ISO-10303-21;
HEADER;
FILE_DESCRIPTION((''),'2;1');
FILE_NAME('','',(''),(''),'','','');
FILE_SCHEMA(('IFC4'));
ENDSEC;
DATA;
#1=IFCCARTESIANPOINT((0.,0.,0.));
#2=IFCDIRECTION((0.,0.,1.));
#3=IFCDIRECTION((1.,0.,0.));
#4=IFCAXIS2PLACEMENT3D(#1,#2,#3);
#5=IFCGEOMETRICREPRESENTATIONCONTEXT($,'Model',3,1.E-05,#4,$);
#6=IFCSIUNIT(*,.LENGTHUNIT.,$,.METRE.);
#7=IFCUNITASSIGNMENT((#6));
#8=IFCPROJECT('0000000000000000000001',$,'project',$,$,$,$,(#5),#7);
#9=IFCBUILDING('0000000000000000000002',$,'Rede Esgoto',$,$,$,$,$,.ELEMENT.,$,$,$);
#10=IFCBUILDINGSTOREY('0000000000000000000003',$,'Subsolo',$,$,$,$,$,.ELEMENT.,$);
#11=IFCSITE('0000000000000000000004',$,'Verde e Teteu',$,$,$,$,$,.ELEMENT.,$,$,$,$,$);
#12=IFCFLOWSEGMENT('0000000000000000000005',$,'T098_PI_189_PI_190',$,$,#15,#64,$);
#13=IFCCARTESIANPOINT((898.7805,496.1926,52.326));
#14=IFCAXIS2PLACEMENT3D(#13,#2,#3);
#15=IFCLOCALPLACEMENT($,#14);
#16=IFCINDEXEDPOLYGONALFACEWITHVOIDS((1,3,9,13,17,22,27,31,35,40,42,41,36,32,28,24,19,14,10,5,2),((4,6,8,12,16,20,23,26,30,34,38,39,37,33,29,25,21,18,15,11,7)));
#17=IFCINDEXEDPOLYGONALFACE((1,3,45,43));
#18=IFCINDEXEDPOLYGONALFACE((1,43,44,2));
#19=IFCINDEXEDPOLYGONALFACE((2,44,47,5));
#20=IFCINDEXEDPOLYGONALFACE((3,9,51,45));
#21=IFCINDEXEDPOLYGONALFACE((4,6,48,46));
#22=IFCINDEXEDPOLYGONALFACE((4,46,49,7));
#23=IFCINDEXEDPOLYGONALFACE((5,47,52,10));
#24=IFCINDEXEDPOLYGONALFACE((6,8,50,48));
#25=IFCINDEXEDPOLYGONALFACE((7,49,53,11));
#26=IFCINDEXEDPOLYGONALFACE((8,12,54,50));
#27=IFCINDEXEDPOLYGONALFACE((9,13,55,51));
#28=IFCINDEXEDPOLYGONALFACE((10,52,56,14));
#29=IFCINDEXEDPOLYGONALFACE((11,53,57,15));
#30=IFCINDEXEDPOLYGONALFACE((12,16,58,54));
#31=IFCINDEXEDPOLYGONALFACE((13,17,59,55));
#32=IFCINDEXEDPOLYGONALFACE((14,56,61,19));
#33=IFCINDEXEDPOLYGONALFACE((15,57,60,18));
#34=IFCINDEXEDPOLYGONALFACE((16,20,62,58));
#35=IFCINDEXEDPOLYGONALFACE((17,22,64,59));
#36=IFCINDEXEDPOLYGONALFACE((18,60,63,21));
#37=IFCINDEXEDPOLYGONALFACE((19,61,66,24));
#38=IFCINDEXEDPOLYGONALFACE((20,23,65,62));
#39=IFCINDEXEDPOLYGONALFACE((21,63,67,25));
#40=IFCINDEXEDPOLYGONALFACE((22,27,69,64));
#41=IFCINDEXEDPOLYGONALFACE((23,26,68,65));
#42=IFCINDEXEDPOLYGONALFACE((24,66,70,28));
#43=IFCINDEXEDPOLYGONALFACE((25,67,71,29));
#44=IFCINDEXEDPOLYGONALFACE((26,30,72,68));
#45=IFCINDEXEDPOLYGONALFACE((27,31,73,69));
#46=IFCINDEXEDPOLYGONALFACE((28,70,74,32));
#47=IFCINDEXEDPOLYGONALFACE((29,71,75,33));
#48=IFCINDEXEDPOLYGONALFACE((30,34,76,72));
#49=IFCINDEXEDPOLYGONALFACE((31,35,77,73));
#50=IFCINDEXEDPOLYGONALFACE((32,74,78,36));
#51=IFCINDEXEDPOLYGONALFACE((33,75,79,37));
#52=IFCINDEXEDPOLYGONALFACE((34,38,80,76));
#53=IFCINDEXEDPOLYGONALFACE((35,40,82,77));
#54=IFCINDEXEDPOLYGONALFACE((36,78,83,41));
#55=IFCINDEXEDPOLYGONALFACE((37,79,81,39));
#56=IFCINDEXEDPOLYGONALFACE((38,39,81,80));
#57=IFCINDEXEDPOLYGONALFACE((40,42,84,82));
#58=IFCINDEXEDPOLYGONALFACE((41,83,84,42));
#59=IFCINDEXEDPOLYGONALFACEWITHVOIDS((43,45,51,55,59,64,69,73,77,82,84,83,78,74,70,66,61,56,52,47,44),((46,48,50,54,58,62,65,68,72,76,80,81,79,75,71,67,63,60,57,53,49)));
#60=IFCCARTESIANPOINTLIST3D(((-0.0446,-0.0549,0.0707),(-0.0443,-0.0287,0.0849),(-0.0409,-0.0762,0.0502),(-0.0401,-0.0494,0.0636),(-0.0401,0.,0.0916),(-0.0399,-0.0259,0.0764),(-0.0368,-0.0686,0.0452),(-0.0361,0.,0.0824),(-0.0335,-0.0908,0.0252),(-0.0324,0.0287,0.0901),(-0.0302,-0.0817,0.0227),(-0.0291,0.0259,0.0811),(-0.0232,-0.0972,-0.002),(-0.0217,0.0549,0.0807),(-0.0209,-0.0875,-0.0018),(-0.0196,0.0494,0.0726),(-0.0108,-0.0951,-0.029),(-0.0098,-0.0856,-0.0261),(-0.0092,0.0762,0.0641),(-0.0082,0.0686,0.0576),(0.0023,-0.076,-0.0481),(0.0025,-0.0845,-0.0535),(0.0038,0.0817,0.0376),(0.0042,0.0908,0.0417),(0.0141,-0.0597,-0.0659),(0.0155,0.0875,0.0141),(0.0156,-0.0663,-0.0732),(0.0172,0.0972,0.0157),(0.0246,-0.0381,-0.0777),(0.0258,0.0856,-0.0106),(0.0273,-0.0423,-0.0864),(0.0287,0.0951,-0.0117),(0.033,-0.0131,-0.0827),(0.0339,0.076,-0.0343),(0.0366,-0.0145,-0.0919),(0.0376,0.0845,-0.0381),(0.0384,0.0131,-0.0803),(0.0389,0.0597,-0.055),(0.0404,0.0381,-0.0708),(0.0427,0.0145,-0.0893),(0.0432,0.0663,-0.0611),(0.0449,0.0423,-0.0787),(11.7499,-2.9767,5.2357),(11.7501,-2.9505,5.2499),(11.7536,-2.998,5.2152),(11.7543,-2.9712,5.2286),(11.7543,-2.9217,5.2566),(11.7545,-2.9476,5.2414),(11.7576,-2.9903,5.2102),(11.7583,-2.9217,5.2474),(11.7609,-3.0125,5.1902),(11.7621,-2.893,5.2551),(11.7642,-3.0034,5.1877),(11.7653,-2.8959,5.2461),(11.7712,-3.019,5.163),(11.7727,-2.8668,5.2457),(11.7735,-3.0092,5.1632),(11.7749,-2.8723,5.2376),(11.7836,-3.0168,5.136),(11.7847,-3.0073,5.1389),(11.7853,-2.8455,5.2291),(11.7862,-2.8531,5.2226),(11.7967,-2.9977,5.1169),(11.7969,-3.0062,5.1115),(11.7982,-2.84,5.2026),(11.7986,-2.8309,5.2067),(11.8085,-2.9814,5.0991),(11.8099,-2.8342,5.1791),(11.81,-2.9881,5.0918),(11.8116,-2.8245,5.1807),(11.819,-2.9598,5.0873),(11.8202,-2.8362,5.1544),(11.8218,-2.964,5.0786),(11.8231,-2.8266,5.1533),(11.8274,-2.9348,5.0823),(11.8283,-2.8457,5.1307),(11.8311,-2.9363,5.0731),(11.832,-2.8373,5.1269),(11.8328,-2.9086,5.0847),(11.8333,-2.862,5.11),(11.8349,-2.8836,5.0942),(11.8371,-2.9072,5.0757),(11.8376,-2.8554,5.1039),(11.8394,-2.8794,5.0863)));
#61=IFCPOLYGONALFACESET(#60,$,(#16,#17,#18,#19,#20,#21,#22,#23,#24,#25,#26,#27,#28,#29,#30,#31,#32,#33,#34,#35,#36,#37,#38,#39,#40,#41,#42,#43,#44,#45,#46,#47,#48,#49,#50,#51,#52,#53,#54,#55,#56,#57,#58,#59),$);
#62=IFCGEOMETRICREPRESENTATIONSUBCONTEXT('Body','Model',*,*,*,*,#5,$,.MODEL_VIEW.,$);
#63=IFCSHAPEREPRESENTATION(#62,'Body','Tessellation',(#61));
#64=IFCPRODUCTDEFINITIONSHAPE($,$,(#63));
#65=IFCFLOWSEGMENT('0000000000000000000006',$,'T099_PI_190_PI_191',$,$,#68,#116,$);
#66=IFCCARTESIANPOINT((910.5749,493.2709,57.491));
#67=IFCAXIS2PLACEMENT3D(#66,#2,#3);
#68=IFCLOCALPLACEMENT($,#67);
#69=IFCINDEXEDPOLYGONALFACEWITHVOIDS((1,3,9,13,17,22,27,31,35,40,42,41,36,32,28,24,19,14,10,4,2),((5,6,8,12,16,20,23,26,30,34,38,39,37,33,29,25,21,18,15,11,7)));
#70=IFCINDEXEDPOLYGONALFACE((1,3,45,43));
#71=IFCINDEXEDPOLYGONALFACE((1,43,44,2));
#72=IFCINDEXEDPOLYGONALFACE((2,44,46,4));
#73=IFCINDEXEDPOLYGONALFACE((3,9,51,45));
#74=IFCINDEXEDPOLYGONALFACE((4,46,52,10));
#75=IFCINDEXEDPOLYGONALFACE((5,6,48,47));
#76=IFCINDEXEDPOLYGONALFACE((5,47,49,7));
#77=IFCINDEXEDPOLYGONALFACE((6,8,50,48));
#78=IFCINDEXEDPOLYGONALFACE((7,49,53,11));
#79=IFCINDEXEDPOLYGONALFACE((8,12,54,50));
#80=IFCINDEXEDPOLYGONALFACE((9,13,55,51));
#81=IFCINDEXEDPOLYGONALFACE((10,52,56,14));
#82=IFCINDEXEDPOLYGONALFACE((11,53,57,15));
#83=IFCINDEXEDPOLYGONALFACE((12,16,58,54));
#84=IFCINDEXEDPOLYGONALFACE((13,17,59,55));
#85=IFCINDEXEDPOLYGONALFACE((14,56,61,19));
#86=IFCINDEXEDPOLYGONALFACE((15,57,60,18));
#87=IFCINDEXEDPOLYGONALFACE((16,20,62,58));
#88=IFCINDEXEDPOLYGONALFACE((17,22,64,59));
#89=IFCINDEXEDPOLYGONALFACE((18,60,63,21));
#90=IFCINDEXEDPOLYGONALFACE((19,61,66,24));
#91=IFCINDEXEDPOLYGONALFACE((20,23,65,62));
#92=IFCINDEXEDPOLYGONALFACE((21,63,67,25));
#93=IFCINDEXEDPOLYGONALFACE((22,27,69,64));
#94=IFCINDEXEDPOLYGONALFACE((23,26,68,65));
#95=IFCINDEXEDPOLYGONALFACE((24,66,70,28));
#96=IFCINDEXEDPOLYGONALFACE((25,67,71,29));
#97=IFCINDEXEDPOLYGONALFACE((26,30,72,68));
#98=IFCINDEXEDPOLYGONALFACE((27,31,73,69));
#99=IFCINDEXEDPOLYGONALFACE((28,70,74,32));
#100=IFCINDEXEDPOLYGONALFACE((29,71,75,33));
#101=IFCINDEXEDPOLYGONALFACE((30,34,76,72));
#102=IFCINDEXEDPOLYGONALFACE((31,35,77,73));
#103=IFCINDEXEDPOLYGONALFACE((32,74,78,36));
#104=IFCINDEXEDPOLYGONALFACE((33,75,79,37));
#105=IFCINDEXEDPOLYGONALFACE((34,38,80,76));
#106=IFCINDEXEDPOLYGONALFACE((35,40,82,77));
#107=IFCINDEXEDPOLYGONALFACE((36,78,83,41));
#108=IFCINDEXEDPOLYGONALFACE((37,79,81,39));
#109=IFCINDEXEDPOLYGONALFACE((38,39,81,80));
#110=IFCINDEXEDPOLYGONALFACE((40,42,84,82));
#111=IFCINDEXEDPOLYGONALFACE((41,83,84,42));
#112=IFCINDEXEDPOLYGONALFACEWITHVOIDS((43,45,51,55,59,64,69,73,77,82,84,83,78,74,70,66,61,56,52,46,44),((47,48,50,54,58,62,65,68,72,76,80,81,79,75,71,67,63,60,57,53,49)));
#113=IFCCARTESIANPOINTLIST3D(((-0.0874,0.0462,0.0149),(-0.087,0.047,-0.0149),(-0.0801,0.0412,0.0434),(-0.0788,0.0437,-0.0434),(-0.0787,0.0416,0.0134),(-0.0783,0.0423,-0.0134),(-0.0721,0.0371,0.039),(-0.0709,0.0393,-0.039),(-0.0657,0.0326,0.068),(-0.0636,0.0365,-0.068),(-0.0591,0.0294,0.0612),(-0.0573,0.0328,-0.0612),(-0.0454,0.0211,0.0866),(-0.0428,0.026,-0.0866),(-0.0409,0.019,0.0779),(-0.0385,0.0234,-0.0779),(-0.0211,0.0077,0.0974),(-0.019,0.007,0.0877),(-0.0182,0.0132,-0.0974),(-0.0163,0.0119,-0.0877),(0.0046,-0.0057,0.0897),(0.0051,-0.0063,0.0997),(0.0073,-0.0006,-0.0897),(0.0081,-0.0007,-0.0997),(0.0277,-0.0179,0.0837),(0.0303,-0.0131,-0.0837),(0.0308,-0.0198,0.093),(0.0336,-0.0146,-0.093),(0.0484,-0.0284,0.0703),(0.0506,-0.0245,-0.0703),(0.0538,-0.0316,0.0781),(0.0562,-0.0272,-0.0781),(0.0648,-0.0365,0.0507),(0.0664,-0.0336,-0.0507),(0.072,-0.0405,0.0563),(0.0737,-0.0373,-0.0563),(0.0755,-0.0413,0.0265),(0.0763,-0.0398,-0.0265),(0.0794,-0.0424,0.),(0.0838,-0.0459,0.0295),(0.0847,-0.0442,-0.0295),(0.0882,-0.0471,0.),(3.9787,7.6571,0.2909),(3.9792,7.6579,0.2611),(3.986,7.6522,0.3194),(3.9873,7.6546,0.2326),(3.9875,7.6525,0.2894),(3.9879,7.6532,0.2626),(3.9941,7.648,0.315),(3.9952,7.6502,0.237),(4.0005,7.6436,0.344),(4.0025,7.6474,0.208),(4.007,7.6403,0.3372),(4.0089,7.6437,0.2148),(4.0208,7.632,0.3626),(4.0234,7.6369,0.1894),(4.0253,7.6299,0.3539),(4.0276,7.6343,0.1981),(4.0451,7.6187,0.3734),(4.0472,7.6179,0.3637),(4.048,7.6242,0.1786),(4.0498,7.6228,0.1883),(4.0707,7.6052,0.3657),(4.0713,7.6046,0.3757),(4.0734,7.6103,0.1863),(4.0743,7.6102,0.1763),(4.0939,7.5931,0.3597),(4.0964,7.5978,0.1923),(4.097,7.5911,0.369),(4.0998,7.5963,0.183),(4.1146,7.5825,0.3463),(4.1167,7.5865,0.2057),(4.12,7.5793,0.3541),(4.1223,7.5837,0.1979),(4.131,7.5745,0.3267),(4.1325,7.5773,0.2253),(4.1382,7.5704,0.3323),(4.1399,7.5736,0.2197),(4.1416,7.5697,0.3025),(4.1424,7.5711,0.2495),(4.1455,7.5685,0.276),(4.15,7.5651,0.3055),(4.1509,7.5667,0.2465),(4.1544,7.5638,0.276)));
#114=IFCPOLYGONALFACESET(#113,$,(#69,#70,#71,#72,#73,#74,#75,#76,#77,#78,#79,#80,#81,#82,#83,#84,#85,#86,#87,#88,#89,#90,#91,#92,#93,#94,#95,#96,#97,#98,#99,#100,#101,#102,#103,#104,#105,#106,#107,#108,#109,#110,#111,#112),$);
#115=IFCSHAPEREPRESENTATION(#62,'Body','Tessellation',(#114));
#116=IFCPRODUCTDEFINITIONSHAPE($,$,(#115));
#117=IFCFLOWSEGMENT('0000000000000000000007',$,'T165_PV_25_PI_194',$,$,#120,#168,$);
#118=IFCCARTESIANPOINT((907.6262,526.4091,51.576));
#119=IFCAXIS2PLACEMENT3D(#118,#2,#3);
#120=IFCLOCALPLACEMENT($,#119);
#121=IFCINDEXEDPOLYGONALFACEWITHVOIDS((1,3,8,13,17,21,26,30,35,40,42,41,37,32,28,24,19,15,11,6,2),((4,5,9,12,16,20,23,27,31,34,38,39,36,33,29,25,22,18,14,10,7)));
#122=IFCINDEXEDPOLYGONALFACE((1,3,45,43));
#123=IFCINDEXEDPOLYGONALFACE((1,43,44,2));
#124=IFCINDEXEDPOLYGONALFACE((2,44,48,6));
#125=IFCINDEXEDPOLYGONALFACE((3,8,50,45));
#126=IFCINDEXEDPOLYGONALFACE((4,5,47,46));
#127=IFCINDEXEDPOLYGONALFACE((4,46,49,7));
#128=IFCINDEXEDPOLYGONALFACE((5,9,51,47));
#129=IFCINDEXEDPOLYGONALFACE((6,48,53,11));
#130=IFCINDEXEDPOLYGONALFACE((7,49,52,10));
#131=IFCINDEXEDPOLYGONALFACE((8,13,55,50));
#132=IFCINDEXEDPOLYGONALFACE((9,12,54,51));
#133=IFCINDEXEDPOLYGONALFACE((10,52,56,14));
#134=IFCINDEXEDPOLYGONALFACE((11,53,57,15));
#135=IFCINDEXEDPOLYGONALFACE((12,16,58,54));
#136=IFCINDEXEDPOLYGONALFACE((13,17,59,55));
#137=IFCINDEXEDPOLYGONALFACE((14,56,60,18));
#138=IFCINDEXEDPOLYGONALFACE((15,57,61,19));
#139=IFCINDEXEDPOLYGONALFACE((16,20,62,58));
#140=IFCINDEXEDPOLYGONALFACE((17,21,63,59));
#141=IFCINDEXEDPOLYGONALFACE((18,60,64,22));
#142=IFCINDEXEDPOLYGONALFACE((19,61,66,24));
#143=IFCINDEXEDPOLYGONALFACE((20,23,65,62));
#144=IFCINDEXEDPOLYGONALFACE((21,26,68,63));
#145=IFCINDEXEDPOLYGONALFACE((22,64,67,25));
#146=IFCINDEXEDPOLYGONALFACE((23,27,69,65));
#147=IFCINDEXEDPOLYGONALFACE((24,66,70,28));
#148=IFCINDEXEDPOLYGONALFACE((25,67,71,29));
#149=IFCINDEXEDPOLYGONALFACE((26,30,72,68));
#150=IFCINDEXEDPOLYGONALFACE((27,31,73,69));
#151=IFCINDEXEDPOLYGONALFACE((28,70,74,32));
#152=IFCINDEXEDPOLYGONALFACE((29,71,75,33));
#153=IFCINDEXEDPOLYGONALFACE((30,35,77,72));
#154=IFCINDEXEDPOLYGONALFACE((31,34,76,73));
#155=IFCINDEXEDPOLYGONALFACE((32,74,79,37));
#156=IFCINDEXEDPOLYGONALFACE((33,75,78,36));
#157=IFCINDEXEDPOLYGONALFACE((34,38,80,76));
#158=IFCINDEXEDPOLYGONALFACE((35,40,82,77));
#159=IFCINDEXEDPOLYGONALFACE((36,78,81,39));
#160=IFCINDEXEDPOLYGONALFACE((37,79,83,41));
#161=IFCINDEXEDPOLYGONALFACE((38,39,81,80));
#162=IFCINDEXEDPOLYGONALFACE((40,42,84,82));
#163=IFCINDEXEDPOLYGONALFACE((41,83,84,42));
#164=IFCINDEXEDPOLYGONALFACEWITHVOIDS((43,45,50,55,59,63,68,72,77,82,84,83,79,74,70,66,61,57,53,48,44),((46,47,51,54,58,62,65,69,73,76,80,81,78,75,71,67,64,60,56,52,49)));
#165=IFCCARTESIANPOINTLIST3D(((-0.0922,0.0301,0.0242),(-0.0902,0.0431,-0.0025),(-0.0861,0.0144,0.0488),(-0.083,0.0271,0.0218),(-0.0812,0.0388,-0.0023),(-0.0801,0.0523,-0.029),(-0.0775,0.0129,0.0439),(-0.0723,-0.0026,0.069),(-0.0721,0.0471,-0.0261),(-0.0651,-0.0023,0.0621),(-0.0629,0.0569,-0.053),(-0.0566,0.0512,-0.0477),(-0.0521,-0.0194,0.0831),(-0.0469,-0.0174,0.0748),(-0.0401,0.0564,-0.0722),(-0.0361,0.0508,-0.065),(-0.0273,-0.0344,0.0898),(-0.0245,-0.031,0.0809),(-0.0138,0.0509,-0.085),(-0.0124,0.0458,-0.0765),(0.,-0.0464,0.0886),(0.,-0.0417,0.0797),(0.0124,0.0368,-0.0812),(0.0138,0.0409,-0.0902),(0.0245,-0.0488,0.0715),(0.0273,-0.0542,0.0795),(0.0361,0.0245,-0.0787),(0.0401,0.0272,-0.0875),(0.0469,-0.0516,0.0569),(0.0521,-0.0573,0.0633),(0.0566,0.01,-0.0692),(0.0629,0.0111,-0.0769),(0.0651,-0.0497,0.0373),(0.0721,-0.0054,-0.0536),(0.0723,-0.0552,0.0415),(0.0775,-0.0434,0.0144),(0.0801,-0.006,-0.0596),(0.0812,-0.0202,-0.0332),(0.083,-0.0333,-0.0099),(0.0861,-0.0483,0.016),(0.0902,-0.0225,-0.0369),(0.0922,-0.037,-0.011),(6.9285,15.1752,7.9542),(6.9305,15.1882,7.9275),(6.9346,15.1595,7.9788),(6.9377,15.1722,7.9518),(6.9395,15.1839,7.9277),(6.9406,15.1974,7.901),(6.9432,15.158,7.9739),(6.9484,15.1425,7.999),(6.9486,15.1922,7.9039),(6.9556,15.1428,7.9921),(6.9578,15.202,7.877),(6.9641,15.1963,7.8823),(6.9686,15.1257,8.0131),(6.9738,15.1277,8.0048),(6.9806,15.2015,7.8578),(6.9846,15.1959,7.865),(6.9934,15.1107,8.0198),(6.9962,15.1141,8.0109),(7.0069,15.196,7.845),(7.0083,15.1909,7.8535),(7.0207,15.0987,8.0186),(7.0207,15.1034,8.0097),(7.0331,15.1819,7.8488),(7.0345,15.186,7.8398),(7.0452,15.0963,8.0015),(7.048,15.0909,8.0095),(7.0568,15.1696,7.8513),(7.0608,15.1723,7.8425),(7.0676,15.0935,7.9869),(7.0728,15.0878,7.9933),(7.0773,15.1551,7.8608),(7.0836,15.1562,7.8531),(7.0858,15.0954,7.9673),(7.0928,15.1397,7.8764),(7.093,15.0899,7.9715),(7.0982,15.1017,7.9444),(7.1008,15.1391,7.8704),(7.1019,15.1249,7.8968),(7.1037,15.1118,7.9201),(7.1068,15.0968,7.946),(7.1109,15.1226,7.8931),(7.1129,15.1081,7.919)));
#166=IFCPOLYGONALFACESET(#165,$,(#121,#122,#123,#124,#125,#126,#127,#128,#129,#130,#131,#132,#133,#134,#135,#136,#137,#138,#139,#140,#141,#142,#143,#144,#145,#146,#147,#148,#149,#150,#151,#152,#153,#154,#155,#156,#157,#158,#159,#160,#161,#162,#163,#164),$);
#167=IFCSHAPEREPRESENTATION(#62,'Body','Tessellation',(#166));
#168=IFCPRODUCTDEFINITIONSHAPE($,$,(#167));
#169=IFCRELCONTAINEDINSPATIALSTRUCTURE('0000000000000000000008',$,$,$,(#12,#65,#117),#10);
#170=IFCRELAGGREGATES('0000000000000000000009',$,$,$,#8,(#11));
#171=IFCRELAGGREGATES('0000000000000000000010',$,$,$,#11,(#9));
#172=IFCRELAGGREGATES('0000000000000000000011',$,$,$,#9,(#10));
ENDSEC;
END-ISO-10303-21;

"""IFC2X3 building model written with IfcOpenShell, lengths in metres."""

from ifc_helpers import new_model, entity, si_unit, frame, origin_with_axes, place, context, subcontext, project, spatial, element, save


model = new_model("IFC2X3")

# Units and contexts
model_context = context("Model", 3, precision=1e-05, world=origin_with_axes())
body_context = subcontext(model_context, "Body", "Model", "MODEL_VIEW")
ifc_project = project(units=[si_unit("LENGTHUNIT", "METRE")], contexts=[model_context])

# Site, building, storey
site = spatial("IfcSite", under=ifc_project, Name="Verde e Teteu", CompositionType="ELEMENT")
building = spatial("IfcBuilding", under=site, Name="Rede Esgoto", CompositionType="ELEMENT")
storey = spatial("IfcBuildingStorey", under=building, Name="Subsolo", CompositionType="ELEMENT")

# Flow segments
flow_segment_1_placement = place(None, frame((898.7805, 496.1926, 52.326), z_axis=(0.0, 0.0, 1.0), x_axis=(1.0, 0.0, 0.0)))
element("IfcFlowSegment", 1, at=flow_segment_1_placement, inside=storey, Name="T098_PI_189_PI_190", context=body_context, shape_type="SweptSolid", body=[
    entity("IfcSweptDiskSolid", entity("IfcPolyline", [entity("IfcCartesianPoint", [0.0, 0.0, 0.0]), entity("IfcCartesianPoint", [11.7944, -2.9217, 5.165])]), 0.1, 0.09),
])
flow_segment_2_placement = place(None, frame((910.5749, 493.2709, 57.491), z_axis=(0.0, 0.0, 1.0), x_axis=(1.0, 0.0, 0.0)))
element("IfcFlowSegment", 2, at=flow_segment_2_placement, inside=storey, Name="T099_PI_190_PI_191", context=body_context, shape_type="SweptSolid", body=[
    entity("IfcSweptDiskSolid", entity("IfcPolyline", [entity("IfcCartesianPoint", [0.0, 0.0, 0.0]), entity("IfcCartesianPoint", [4.0662, 7.6109, 0.276])]), 0.1, 0.09),
])
flow_segment_3_placement = place(None, frame((907.6262, 526.4091, 51.576), z_axis=(0.0, 0.0, 1.0), x_axis=(1.0, 0.0, 0.0)))
element("IfcFlowSegment", 3, at=flow_segment_3_placement, inside=storey, Name="T165_PV_25_PI_194", context=body_context, shape_type="SweptSolid", body=[
    entity("IfcSweptDiskSolid", entity("IfcPolyline", [entity("IfcCartesianPoint", [0.0, 0.0, 0.0]), entity("IfcCartesianPoint", [7.0207, 15.1451, 7.93])]), 0.1, 0.09),
])

save(model, "model.ifc")
